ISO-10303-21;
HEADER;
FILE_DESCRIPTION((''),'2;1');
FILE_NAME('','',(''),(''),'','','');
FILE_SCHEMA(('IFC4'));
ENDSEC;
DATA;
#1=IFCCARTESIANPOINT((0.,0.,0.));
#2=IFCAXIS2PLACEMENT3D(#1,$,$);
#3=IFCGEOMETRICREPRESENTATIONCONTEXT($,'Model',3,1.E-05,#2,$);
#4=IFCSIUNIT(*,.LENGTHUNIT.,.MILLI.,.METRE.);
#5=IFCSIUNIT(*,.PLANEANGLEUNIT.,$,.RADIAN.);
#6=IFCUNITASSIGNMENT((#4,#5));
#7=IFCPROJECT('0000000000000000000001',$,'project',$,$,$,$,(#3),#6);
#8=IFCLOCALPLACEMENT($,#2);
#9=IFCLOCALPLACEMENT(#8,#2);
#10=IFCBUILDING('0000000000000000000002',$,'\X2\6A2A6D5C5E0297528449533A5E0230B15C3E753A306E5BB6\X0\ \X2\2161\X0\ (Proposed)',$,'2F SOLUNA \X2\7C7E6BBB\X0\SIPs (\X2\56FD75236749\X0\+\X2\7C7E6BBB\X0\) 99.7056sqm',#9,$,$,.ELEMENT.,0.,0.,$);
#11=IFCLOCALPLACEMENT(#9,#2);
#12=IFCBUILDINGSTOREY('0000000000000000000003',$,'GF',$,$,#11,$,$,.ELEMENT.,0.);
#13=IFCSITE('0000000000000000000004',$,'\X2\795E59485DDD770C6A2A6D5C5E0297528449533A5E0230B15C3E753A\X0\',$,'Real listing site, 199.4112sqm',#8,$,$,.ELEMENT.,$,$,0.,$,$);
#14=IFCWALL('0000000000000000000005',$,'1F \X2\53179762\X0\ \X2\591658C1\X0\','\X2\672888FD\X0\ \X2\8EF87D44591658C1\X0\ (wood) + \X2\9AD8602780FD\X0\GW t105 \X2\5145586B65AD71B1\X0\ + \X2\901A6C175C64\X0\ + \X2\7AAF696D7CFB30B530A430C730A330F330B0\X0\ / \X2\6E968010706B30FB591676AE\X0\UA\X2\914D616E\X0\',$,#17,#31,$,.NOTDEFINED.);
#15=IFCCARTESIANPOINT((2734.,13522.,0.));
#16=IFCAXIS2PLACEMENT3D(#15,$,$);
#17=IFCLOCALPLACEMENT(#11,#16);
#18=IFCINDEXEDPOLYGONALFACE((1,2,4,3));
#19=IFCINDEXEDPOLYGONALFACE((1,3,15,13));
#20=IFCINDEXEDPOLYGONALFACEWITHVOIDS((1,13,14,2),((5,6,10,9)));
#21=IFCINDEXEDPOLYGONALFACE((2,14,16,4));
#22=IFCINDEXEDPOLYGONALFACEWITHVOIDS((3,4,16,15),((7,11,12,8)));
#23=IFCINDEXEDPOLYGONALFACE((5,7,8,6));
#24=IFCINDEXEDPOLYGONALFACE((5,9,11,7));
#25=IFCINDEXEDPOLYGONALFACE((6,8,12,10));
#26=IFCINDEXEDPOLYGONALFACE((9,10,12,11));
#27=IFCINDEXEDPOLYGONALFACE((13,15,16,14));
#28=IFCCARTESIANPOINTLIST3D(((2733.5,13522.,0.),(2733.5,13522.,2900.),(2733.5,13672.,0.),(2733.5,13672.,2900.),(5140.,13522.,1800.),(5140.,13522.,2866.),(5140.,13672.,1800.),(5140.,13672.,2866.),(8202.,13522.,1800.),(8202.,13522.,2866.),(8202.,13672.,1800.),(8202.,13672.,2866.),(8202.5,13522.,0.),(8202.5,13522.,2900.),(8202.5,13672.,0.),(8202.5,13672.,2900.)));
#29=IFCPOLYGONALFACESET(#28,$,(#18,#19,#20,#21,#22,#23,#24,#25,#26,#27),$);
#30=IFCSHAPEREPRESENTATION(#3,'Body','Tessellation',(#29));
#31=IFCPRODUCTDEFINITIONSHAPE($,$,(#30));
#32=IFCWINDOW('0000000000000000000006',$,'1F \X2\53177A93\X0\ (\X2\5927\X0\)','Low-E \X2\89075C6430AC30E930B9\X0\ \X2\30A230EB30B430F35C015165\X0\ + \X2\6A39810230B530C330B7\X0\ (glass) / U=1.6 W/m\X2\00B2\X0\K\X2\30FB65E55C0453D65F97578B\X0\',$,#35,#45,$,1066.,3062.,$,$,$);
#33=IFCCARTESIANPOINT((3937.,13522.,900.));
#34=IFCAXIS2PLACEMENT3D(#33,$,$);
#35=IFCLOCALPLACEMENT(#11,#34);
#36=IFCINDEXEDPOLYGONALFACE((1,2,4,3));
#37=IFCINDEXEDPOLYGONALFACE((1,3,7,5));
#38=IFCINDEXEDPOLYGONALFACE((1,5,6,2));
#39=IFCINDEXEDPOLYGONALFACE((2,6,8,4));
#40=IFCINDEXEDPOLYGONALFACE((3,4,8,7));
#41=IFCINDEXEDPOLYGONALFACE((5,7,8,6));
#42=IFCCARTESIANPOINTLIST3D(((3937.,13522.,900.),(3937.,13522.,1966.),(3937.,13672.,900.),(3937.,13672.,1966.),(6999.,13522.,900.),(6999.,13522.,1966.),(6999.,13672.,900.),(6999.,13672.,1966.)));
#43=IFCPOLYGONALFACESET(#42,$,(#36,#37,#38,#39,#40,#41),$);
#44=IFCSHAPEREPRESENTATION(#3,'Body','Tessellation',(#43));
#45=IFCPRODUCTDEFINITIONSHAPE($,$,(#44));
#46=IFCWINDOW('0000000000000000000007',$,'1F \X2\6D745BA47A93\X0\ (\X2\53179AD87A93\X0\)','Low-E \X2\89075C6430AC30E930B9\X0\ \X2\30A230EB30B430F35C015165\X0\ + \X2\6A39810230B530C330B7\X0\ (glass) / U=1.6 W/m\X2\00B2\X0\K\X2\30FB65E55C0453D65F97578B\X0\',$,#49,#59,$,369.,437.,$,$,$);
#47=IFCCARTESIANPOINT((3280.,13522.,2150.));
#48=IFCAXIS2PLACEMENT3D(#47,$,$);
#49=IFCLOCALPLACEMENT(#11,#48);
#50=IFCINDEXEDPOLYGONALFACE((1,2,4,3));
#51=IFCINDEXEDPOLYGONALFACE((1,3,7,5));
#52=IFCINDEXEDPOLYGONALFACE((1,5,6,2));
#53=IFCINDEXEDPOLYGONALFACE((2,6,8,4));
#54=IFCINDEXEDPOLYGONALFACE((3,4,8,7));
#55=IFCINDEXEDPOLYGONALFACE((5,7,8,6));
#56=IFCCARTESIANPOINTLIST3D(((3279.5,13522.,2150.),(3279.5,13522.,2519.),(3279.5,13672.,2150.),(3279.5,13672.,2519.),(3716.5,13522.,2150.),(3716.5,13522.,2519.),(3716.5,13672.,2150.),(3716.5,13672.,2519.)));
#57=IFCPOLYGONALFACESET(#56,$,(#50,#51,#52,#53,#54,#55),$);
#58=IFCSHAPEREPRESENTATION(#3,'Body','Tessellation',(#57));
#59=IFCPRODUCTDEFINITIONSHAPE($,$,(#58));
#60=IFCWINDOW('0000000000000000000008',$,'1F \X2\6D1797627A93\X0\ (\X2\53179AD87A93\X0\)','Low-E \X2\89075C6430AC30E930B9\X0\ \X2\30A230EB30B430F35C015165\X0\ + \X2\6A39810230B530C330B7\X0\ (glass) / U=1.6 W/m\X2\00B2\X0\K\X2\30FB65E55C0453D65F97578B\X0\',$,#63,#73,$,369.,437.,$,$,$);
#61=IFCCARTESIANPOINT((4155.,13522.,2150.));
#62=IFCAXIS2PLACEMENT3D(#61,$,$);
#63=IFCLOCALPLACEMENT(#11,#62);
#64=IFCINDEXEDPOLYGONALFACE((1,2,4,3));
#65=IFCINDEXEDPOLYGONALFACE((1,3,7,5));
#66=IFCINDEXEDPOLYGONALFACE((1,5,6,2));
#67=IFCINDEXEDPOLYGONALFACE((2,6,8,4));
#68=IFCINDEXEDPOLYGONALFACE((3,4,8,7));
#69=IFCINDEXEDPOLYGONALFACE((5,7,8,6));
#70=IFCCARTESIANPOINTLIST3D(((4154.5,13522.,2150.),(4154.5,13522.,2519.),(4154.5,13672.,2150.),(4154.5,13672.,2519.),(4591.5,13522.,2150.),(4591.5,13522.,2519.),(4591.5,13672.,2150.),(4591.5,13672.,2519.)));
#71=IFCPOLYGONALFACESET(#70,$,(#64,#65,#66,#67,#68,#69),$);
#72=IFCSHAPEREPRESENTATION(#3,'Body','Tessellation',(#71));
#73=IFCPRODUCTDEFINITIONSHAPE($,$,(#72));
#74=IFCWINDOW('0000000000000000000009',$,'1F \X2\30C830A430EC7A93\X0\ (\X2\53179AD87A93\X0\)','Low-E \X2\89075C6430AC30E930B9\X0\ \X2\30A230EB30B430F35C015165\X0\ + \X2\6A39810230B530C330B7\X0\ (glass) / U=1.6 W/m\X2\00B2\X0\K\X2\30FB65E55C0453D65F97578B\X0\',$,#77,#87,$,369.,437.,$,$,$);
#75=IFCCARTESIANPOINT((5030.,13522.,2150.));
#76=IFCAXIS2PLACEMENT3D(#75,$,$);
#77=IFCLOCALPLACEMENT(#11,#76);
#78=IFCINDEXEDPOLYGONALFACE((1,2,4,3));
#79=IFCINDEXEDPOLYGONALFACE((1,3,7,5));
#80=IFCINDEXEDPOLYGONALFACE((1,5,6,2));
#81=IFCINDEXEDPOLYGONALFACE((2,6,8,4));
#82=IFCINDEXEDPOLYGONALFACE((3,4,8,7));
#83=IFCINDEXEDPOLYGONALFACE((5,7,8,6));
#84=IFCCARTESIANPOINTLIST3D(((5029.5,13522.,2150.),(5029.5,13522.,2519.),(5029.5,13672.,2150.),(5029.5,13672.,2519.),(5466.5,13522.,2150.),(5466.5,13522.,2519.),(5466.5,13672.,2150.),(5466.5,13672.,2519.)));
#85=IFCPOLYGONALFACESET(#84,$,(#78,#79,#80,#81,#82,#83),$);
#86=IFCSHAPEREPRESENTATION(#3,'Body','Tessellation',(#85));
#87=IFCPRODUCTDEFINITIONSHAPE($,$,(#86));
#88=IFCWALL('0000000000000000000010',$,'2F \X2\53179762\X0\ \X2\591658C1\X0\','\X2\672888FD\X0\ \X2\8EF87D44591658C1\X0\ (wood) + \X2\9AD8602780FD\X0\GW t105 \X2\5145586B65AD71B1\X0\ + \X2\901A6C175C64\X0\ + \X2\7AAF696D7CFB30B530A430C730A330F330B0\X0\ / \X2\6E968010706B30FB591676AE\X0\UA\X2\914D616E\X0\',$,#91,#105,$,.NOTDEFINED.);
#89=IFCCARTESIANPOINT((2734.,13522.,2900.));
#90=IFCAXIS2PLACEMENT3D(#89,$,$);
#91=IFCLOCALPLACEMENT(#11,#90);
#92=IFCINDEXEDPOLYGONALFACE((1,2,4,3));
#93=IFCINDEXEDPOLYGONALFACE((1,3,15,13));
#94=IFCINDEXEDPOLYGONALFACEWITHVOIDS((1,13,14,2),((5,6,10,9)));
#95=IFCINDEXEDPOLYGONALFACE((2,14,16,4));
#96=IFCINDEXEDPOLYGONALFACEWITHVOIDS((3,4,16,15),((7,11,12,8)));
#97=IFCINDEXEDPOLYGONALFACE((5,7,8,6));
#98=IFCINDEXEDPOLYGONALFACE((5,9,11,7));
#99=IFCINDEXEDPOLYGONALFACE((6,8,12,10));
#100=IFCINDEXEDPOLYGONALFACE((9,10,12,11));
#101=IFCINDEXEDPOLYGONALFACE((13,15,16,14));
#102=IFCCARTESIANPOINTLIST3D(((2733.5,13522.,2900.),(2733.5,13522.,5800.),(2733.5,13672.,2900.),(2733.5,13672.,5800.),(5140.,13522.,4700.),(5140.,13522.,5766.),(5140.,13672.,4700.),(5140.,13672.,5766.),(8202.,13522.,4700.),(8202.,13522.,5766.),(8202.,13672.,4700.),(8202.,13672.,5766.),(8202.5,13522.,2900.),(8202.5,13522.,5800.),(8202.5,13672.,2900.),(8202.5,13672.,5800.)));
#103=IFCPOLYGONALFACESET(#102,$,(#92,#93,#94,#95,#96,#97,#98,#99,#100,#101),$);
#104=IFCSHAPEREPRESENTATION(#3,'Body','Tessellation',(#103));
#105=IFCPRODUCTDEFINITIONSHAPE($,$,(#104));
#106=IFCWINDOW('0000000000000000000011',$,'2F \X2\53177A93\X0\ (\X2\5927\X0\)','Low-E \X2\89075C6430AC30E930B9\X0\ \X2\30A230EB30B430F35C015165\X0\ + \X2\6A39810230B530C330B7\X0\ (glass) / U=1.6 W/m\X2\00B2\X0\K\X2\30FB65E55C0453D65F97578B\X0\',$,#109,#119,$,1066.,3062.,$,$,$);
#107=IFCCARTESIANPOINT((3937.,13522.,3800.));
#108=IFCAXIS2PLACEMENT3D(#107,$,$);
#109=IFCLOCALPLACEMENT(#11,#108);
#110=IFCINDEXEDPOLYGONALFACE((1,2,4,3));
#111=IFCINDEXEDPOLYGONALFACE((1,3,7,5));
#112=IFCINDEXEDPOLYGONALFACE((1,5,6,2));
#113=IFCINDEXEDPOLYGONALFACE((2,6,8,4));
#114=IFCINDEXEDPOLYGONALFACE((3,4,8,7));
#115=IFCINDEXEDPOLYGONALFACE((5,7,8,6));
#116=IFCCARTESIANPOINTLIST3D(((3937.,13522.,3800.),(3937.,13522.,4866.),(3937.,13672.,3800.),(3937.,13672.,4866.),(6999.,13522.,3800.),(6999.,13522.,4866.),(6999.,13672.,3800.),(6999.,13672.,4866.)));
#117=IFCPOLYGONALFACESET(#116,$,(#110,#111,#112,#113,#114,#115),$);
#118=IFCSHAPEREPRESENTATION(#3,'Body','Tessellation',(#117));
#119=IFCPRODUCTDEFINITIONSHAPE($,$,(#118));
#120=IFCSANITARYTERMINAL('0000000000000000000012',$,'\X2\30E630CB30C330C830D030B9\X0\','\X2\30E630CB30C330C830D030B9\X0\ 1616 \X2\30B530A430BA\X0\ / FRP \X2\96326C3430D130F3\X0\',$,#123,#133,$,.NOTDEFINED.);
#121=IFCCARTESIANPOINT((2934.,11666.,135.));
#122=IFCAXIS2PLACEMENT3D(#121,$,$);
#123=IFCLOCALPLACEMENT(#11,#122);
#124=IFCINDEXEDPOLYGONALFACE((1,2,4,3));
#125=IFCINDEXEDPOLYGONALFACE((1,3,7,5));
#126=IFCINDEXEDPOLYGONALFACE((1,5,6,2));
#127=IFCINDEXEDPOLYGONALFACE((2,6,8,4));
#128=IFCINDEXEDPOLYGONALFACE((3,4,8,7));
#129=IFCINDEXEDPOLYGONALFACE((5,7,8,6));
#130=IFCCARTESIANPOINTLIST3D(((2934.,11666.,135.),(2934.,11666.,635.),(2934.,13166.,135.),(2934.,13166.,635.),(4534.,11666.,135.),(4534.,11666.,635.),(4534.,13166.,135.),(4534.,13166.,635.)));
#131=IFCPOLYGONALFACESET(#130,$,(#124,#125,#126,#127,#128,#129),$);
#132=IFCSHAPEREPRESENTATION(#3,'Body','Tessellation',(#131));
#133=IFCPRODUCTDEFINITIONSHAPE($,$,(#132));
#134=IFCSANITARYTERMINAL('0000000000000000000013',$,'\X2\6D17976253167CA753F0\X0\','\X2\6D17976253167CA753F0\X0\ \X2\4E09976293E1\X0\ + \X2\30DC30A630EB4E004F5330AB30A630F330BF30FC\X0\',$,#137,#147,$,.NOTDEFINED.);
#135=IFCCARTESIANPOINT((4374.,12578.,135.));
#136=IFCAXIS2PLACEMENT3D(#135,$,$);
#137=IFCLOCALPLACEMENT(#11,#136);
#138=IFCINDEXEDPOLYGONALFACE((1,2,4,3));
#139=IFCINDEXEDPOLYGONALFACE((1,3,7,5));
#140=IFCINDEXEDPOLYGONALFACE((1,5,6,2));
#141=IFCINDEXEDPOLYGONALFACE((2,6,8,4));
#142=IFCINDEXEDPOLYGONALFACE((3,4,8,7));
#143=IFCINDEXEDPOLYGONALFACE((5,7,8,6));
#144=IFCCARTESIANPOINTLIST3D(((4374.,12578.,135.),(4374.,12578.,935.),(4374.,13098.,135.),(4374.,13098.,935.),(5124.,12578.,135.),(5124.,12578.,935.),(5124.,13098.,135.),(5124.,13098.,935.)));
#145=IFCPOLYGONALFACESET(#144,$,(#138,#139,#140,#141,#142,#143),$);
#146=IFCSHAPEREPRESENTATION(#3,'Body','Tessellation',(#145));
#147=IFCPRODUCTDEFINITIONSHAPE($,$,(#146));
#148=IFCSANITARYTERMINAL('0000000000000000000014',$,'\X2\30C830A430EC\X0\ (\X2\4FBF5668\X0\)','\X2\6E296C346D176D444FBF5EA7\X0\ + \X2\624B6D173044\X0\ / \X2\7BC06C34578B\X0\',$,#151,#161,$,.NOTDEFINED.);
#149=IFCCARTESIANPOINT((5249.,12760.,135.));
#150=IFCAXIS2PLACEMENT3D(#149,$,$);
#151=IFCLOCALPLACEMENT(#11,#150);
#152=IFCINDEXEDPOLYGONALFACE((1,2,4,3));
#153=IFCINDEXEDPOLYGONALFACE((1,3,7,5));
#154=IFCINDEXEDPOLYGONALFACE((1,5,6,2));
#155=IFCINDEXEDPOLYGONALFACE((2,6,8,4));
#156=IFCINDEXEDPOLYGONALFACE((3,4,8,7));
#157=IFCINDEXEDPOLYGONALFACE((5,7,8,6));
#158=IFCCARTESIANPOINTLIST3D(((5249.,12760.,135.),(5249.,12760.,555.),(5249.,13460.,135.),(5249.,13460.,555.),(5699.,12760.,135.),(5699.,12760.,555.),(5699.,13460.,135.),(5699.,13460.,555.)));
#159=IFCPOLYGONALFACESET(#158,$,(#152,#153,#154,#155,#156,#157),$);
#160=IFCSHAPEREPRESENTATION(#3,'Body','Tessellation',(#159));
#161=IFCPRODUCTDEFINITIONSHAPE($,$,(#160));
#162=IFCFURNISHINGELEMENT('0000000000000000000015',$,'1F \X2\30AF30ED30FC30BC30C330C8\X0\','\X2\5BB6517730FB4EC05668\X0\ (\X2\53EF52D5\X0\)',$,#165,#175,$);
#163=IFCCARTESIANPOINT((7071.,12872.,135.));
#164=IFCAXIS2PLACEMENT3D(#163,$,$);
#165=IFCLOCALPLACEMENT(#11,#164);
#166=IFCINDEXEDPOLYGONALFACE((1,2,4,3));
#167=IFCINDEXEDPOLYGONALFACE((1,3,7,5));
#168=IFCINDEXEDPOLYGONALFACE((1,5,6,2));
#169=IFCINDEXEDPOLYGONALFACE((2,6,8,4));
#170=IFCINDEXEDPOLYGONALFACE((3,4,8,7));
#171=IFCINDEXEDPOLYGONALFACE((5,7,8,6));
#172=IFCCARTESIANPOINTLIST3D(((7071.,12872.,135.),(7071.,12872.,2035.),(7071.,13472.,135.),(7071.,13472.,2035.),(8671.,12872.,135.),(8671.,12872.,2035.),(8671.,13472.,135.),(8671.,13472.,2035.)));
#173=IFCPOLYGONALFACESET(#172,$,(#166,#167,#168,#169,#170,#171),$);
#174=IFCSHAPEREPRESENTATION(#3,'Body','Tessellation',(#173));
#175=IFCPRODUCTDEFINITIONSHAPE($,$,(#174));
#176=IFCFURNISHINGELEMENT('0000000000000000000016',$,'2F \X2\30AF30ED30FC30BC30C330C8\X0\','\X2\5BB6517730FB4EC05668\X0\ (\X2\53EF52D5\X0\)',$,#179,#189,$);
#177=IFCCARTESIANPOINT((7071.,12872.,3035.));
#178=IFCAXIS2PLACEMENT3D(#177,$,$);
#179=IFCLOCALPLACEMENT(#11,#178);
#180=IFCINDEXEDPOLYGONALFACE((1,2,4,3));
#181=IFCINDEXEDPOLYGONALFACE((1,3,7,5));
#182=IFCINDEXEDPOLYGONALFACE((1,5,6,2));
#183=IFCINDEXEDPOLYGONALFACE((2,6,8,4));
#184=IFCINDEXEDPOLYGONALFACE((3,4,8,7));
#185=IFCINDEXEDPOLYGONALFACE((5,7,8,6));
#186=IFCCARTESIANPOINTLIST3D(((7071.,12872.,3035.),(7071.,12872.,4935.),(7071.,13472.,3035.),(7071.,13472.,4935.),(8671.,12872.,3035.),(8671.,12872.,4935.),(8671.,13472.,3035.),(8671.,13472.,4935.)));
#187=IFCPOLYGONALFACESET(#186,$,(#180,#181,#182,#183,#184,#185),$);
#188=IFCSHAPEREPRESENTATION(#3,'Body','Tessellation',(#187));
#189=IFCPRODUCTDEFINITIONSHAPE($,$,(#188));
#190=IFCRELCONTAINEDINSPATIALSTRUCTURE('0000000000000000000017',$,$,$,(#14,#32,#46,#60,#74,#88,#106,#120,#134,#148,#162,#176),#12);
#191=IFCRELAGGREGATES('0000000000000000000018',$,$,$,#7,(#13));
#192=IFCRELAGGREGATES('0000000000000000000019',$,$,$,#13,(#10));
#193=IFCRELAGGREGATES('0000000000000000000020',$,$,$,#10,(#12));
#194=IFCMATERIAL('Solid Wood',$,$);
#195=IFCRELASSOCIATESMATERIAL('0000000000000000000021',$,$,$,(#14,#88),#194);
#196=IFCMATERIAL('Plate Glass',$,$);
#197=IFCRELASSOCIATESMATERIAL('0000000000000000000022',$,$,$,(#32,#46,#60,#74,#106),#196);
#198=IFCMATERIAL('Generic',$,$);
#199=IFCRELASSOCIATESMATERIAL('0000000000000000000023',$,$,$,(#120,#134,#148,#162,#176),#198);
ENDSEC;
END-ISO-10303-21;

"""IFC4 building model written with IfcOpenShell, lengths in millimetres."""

from ifc_helpers import new_model, si_unit, frame, frame_2d, origin, place, context, project, spatial, rectangle, extrude, material, element, fill, save


model = new_model("IFC4")

# Units and contexts
model_context = context("Model", 3, precision=1e-05, world=origin())
ifc_project = project(units=[si_unit("LENGTHUNIT", "METRE", prefix="MILLI"), si_unit("PLANEANGLEUNIT", "RADIAN")], contexts=[model_context])

# Site, building, storey
site_placement = place(None, origin())
site = spatial("IfcSite", under=ifc_project, at=site_placement, Name="神奈川県横浜市青葉区市ケ尾町", ObjectType="Real listing site, 199.4112sqm", CompositionType="ELEMENT", RefElevation=0.0)
building_placement = place(site_placement, origin())
building = spatial("IfcBuilding", under=site, at=building_placement, Name="横浜市青葉区市ケ尾町の家 Ⅱ (Proposed)", ObjectType="2F SOLUNA 籾殻SIPs (国産杉+籾殻) 99.7056sqm", CompositionType="ELEMENT", ElevationOfRefHeight=0.0, ElevationOfTerrain=0.0)
storey_placement = place(building_placement, origin())
storey = spatial("IfcBuildingStorey", under=building, at=storey_placement, Name="GF", CompositionType="ELEMENT", Elevation=0.0)

# Wall, openings, windows
ifc_material_1 = material(Name="Solid Wood")
wall_1_placement = place(storey_placement, frame((2734.0, 13522.0, 0.0)))
wall_1 = element("IfcWall", 1, at=wall_1_placement, inside=storey, material=ifc_material_1, Name="1F 北面 外壁", Description="木製 軸組外壁 (wood) + 高性能GW t105 充填断熱 + 通気層 + 窯業系サイディング / 準耐火・外皮UA配慮", PredefinedType="NOTDEFINED", context=model_context, shape_type="SweptSolid", body=[
    extrude(rectangle(XDim=5469.0, YDim=150.0, at=frame_2d((2734.0, 75.0))), frame((2734.0, 13522.0, 0.0)), (0.0, 0.0, 1.0), 2900.0),
])
opening_1_placement = place(storey_placement, frame((3937.0, 13522.0, 900.0)))
opening_1 = element("IfcOpeningElement", 2, at=opening_1_placement, cuts=wall_1, PredefinedType="NOTDEFINED", context=model_context, shape_type="SweptSolid", body=[
    extrude(rectangle(XDim=3062.0, YDim=150.0, at=frame_2d((1531.0, 75.0))), frame((3937.0, 13522.0, 900.0)), (0.0, 0.0, 1.0), 1066.0),
])
opening_2_placement = place(storey_placement, frame((3280.0, 13522.0, 2150.0)))
opening_2 = element("IfcOpeningElement", 3, at=opening_2_placement, cuts=wall_1, PredefinedType="NOTDEFINED", context=model_context, shape_type="SweptSolid", body=[
    extrude(rectangle(XDim=437.0, YDim=150.0, at=frame_2d((218.0, 75.0))), frame((3280.0, 13522.0, 2150.0)), (0.0, 0.0, 1.0), 369.0),
])
opening_3_placement = place(storey_placement, frame((4155.0, 13522.0, 2150.0)))
opening_3 = element("IfcOpeningElement", 4, at=opening_3_placement, cuts=wall_1, PredefinedType="NOTDEFINED", context=model_context, shape_type="SweptSolid", body=[
    extrude(rectangle(XDim=437.0, YDim=150.0, at=frame_2d((218.0, 75.0))), frame((4155.0, 13522.0, 2150.0)), (0.0, 0.0, 1.0), 369.0),
])
opening_4_placement = place(storey_placement, frame((5030.0, 13522.0, 2150.0)))
opening_4 = element("IfcOpeningElement", 5, at=opening_4_placement, cuts=wall_1, PredefinedType="NOTDEFINED", context=model_context, shape_type="SweptSolid", body=[
    extrude(rectangle(XDim=437.0, YDim=150.0, at=frame_2d((218.0, 75.0))), frame((5030.0, 13522.0, 2150.0)), (0.0, 0.0, 1.0), 369.0),
])
ifc_material_2 = material(Name="Plate Glass")
window_1_placement = place(storey_placement, frame((3937.0, 13522.0, 900.0)))
window_1 = element("IfcWindow", 6, at=window_1_placement, inside=storey, material=ifc_material_2, Name="1F 北窓 (大)", Description="Low-E 複層ガラス アルゴン封入 + 樹脂サッシ (glass) / U=1.6 W/m²K・日射取得型", OverallHeight=1066.0, OverallWidth=3062.0, context=model_context, shape_type="SweptSolid", body=[
    extrude(rectangle(XDim=3062.0, YDim=150.0, at=frame_2d((1531.0, 75.0))), frame((3937.0, 13522.0, 900.0)), (0.0, 0.0, 1.0), 1066.0),
])
fill(opening_1, window_1)
window_2_placement = place(storey_placement, frame((3280.0, 13522.0, 2150.0)))
window_2 = element("IfcWindow", 7, at=window_2_placement, inside=storey, material=ifc_material_2, Name="1F 浴室窓 (北高窓)", Description="Low-E 複層ガラス アルゴン封入 + 樹脂サッシ (glass) / U=1.6 W/m²K・日射取得型", OverallHeight=369.0, OverallWidth=437.0, context=model_context, shape_type="SweptSolid", body=[
    extrude(rectangle(XDim=437.0, YDim=150.0, at=frame_2d((218.0, 75.0))), frame((3280.0, 13522.0, 2150.0)), (0.0, 0.0, 1.0), 369.0),
])
fill(opening_2, window_2)
window_3_placement = place(storey_placement, frame((4155.0, 13522.0, 2150.0)))
window_3 = element("IfcWindow", 8, at=window_3_placement, inside=storey, material=ifc_material_2, Name="1F 洗面窓 (北高窓)", Description="Low-E 複層ガラス アルゴン封入 + 樹脂サッシ (glass) / U=1.6 W/m²K・日射取得型", OverallHeight=369.0, OverallWidth=437.0, context=model_context, shape_type="SweptSolid", body=[
    extrude(rectangle(XDim=437.0, YDim=150.0, at=frame_2d((218.0, 75.0))), frame((4155.0, 13522.0, 2150.0)), (0.0, 0.0, 1.0), 369.0),
])
fill(opening_3, window_3)
window_4_placement = place(storey_placement, frame((5030.0, 13522.0, 2150.0)))
window_4 = element("IfcWindow", 9, at=window_4_placement, inside=storey, material=ifc_material_2, Name="1F トイレ窓 (北高窓)", Description="Low-E 複層ガラス アルゴン封入 + 樹脂サッシ (glass) / U=1.6 W/m²K・日射取得型", OverallHeight=369.0, OverallWidth=437.0, context=model_context, shape_type="SweptSolid", body=[
    extrude(rectangle(XDim=437.0, YDim=150.0, at=frame_2d((218.0, 75.0))), frame((5030.0, 13522.0, 2150.0)), (0.0, 0.0, 1.0), 369.0),
])
fill(opening_4, window_4)

# Wall, opening, window
wall_2_placement = place(storey_placement, frame((2734.0, 13522.0, 2900.0)))
wall_2 = element("IfcWall", 10, at=wall_2_placement, inside=storey, material=ifc_material_1, Name="2F 北面 外壁", Description="木製 軸組外壁 (wood) + 高性能GW t105 充填断熱 + 通気層 + 窯業系サイディング / 準耐火・外皮UA配慮", PredefinedType="NOTDEFINED", context=model_context, shape_type="SweptSolid", body=[
    extrude(rectangle(XDim=5469.0, YDim=150.0, at=frame_2d((2734.0, 75.0))), frame((2734.0, 13522.0, 2900.0)), (0.0, 0.0, 1.0), 2900.0),
])
opening_5_placement = place(storey_placement, frame((3937.0, 13522.0, 3800.0)))
opening_5 = element("IfcOpeningElement", 11, at=opening_5_placement, cuts=wall_2, PredefinedType="NOTDEFINED", context=model_context, shape_type="SweptSolid", body=[
    extrude(rectangle(XDim=3062.0, YDim=150.0, at=frame_2d((1531.0, 75.0))), frame((3937.0, 13522.0, 3800.0)), (0.0, 0.0, 1.0), 1066.0),
])
window_5_placement = place(storey_placement, frame((3937.0, 13522.0, 3800.0)))
window_5 = element("IfcWindow", 12, at=window_5_placement, inside=storey, material=ifc_material_2, Name="2F 北窓 (大)", Description="Low-E 複層ガラス アルゴン封入 + 樹脂サッシ (glass) / U=1.6 W/m²K・日射取得型", OverallHeight=1066.0, OverallWidth=3062.0, context=model_context, shape_type="SweptSolid", body=[
    extrude(rectangle(XDim=3062.0, YDim=150.0, at=frame_2d((1531.0, 75.0))), frame((3937.0, 13522.0, 3800.0)), (0.0, 0.0, 1.0), 1066.0),
])
fill(opening_5, window_5)

# Sanitary terminals
ifc_material_3 = material(Name="Generic")
sanitary_terminal_1_placement = place(storey_placement, frame((2934.0, 11666.0, 135.0)))
element("IfcSanitaryTerminal", 13, at=sanitary_terminal_1_placement, inside=storey, material=ifc_material_3, Name="ユニットバス", Description="ユニットバス 1616 サイズ / FRP 防水パン", PredefinedType="NOTDEFINED", context=model_context, shape_type="SweptSolid", body=[
    extrude(rectangle(XDim=1600.0, YDim=1500.0, at=frame_2d((800.0, 750.0))), frame((2934.0, 11666.0, 135.0)), (0.0, 0.0, 1.0), 500.0),
])
sanitary_terminal_2_placement = place(storey_placement, frame((4374.0, 12578.0, 135.0)))
element("IfcSanitaryTerminal", 14, at=sanitary_terminal_2_placement, inside=storey, material=ifc_material_3, Name="洗面化粧台", Description="洗面化粧台 三面鏡 + ボウル一体カウンター", PredefinedType="NOTDEFINED", context=model_context, shape_type="SweptSolid", body=[
    extrude(rectangle(XDim=750.0, YDim=520.0, at=frame_2d((375.0, 260.0))), frame((4374.0, 12578.0, 135.0)), (0.0, 0.0, 1.0), 800.0),
])
sanitary_terminal_3_placement = place(storey_placement, frame((5249.0, 12760.0, 135.0)))
element("IfcSanitaryTerminal", 15, at=sanitary_terminal_3_placement, inside=storey, material=ifc_material_3, Name="トイレ (便器)", Description="温水洗浄便座 + 手洗い / 節水型", PredefinedType="NOTDEFINED", context=model_context, shape_type="SweptSolid", body=[
    extrude(rectangle(XDim=450.0, YDim=700.0, at=frame_2d((225.0, 350.0))), frame((5249.0, 12760.0, 135.0)), (0.0, 0.0, 1.0), 420.0),
])

# Furnishing elements
furnishing_1_placement = place(storey_placement, frame((7071.0, 12872.0, 135.0)))
element("IfcFurnishingElement", 16, at=furnishing_1_placement, inside=storey, material=ifc_material_3, Name="1F クローゼット", Description="家具・什器 (可動)", context=model_context, shape_type="SweptSolid", body=[
    extrude(rectangle(XDim=1600.0, YDim=600.0, at=frame_2d((800.0, 300.0))), frame((7071.0, 12872.0, 135.0)), (0.0, 0.0, 1.0), 1900.0),
])
furnishing_2_placement = place(storey_placement, frame((7071.0, 12872.0, 3035.0)))
element("IfcFurnishingElement", 17, at=furnishing_2_placement, inside=storey, material=ifc_material_3, Name="2F クローゼット", Description="家具・什器 (可動)", context=model_context, shape_type="SweptSolid", body=[
    extrude(rectangle(XDim=1600.0, YDim=600.0, at=frame_2d((800.0, 300.0))), frame((7071.0, 12872.0, 3035.0)), (0.0, 0.0, 1.0), 1900.0),
])

save(model, "model.ifc")
